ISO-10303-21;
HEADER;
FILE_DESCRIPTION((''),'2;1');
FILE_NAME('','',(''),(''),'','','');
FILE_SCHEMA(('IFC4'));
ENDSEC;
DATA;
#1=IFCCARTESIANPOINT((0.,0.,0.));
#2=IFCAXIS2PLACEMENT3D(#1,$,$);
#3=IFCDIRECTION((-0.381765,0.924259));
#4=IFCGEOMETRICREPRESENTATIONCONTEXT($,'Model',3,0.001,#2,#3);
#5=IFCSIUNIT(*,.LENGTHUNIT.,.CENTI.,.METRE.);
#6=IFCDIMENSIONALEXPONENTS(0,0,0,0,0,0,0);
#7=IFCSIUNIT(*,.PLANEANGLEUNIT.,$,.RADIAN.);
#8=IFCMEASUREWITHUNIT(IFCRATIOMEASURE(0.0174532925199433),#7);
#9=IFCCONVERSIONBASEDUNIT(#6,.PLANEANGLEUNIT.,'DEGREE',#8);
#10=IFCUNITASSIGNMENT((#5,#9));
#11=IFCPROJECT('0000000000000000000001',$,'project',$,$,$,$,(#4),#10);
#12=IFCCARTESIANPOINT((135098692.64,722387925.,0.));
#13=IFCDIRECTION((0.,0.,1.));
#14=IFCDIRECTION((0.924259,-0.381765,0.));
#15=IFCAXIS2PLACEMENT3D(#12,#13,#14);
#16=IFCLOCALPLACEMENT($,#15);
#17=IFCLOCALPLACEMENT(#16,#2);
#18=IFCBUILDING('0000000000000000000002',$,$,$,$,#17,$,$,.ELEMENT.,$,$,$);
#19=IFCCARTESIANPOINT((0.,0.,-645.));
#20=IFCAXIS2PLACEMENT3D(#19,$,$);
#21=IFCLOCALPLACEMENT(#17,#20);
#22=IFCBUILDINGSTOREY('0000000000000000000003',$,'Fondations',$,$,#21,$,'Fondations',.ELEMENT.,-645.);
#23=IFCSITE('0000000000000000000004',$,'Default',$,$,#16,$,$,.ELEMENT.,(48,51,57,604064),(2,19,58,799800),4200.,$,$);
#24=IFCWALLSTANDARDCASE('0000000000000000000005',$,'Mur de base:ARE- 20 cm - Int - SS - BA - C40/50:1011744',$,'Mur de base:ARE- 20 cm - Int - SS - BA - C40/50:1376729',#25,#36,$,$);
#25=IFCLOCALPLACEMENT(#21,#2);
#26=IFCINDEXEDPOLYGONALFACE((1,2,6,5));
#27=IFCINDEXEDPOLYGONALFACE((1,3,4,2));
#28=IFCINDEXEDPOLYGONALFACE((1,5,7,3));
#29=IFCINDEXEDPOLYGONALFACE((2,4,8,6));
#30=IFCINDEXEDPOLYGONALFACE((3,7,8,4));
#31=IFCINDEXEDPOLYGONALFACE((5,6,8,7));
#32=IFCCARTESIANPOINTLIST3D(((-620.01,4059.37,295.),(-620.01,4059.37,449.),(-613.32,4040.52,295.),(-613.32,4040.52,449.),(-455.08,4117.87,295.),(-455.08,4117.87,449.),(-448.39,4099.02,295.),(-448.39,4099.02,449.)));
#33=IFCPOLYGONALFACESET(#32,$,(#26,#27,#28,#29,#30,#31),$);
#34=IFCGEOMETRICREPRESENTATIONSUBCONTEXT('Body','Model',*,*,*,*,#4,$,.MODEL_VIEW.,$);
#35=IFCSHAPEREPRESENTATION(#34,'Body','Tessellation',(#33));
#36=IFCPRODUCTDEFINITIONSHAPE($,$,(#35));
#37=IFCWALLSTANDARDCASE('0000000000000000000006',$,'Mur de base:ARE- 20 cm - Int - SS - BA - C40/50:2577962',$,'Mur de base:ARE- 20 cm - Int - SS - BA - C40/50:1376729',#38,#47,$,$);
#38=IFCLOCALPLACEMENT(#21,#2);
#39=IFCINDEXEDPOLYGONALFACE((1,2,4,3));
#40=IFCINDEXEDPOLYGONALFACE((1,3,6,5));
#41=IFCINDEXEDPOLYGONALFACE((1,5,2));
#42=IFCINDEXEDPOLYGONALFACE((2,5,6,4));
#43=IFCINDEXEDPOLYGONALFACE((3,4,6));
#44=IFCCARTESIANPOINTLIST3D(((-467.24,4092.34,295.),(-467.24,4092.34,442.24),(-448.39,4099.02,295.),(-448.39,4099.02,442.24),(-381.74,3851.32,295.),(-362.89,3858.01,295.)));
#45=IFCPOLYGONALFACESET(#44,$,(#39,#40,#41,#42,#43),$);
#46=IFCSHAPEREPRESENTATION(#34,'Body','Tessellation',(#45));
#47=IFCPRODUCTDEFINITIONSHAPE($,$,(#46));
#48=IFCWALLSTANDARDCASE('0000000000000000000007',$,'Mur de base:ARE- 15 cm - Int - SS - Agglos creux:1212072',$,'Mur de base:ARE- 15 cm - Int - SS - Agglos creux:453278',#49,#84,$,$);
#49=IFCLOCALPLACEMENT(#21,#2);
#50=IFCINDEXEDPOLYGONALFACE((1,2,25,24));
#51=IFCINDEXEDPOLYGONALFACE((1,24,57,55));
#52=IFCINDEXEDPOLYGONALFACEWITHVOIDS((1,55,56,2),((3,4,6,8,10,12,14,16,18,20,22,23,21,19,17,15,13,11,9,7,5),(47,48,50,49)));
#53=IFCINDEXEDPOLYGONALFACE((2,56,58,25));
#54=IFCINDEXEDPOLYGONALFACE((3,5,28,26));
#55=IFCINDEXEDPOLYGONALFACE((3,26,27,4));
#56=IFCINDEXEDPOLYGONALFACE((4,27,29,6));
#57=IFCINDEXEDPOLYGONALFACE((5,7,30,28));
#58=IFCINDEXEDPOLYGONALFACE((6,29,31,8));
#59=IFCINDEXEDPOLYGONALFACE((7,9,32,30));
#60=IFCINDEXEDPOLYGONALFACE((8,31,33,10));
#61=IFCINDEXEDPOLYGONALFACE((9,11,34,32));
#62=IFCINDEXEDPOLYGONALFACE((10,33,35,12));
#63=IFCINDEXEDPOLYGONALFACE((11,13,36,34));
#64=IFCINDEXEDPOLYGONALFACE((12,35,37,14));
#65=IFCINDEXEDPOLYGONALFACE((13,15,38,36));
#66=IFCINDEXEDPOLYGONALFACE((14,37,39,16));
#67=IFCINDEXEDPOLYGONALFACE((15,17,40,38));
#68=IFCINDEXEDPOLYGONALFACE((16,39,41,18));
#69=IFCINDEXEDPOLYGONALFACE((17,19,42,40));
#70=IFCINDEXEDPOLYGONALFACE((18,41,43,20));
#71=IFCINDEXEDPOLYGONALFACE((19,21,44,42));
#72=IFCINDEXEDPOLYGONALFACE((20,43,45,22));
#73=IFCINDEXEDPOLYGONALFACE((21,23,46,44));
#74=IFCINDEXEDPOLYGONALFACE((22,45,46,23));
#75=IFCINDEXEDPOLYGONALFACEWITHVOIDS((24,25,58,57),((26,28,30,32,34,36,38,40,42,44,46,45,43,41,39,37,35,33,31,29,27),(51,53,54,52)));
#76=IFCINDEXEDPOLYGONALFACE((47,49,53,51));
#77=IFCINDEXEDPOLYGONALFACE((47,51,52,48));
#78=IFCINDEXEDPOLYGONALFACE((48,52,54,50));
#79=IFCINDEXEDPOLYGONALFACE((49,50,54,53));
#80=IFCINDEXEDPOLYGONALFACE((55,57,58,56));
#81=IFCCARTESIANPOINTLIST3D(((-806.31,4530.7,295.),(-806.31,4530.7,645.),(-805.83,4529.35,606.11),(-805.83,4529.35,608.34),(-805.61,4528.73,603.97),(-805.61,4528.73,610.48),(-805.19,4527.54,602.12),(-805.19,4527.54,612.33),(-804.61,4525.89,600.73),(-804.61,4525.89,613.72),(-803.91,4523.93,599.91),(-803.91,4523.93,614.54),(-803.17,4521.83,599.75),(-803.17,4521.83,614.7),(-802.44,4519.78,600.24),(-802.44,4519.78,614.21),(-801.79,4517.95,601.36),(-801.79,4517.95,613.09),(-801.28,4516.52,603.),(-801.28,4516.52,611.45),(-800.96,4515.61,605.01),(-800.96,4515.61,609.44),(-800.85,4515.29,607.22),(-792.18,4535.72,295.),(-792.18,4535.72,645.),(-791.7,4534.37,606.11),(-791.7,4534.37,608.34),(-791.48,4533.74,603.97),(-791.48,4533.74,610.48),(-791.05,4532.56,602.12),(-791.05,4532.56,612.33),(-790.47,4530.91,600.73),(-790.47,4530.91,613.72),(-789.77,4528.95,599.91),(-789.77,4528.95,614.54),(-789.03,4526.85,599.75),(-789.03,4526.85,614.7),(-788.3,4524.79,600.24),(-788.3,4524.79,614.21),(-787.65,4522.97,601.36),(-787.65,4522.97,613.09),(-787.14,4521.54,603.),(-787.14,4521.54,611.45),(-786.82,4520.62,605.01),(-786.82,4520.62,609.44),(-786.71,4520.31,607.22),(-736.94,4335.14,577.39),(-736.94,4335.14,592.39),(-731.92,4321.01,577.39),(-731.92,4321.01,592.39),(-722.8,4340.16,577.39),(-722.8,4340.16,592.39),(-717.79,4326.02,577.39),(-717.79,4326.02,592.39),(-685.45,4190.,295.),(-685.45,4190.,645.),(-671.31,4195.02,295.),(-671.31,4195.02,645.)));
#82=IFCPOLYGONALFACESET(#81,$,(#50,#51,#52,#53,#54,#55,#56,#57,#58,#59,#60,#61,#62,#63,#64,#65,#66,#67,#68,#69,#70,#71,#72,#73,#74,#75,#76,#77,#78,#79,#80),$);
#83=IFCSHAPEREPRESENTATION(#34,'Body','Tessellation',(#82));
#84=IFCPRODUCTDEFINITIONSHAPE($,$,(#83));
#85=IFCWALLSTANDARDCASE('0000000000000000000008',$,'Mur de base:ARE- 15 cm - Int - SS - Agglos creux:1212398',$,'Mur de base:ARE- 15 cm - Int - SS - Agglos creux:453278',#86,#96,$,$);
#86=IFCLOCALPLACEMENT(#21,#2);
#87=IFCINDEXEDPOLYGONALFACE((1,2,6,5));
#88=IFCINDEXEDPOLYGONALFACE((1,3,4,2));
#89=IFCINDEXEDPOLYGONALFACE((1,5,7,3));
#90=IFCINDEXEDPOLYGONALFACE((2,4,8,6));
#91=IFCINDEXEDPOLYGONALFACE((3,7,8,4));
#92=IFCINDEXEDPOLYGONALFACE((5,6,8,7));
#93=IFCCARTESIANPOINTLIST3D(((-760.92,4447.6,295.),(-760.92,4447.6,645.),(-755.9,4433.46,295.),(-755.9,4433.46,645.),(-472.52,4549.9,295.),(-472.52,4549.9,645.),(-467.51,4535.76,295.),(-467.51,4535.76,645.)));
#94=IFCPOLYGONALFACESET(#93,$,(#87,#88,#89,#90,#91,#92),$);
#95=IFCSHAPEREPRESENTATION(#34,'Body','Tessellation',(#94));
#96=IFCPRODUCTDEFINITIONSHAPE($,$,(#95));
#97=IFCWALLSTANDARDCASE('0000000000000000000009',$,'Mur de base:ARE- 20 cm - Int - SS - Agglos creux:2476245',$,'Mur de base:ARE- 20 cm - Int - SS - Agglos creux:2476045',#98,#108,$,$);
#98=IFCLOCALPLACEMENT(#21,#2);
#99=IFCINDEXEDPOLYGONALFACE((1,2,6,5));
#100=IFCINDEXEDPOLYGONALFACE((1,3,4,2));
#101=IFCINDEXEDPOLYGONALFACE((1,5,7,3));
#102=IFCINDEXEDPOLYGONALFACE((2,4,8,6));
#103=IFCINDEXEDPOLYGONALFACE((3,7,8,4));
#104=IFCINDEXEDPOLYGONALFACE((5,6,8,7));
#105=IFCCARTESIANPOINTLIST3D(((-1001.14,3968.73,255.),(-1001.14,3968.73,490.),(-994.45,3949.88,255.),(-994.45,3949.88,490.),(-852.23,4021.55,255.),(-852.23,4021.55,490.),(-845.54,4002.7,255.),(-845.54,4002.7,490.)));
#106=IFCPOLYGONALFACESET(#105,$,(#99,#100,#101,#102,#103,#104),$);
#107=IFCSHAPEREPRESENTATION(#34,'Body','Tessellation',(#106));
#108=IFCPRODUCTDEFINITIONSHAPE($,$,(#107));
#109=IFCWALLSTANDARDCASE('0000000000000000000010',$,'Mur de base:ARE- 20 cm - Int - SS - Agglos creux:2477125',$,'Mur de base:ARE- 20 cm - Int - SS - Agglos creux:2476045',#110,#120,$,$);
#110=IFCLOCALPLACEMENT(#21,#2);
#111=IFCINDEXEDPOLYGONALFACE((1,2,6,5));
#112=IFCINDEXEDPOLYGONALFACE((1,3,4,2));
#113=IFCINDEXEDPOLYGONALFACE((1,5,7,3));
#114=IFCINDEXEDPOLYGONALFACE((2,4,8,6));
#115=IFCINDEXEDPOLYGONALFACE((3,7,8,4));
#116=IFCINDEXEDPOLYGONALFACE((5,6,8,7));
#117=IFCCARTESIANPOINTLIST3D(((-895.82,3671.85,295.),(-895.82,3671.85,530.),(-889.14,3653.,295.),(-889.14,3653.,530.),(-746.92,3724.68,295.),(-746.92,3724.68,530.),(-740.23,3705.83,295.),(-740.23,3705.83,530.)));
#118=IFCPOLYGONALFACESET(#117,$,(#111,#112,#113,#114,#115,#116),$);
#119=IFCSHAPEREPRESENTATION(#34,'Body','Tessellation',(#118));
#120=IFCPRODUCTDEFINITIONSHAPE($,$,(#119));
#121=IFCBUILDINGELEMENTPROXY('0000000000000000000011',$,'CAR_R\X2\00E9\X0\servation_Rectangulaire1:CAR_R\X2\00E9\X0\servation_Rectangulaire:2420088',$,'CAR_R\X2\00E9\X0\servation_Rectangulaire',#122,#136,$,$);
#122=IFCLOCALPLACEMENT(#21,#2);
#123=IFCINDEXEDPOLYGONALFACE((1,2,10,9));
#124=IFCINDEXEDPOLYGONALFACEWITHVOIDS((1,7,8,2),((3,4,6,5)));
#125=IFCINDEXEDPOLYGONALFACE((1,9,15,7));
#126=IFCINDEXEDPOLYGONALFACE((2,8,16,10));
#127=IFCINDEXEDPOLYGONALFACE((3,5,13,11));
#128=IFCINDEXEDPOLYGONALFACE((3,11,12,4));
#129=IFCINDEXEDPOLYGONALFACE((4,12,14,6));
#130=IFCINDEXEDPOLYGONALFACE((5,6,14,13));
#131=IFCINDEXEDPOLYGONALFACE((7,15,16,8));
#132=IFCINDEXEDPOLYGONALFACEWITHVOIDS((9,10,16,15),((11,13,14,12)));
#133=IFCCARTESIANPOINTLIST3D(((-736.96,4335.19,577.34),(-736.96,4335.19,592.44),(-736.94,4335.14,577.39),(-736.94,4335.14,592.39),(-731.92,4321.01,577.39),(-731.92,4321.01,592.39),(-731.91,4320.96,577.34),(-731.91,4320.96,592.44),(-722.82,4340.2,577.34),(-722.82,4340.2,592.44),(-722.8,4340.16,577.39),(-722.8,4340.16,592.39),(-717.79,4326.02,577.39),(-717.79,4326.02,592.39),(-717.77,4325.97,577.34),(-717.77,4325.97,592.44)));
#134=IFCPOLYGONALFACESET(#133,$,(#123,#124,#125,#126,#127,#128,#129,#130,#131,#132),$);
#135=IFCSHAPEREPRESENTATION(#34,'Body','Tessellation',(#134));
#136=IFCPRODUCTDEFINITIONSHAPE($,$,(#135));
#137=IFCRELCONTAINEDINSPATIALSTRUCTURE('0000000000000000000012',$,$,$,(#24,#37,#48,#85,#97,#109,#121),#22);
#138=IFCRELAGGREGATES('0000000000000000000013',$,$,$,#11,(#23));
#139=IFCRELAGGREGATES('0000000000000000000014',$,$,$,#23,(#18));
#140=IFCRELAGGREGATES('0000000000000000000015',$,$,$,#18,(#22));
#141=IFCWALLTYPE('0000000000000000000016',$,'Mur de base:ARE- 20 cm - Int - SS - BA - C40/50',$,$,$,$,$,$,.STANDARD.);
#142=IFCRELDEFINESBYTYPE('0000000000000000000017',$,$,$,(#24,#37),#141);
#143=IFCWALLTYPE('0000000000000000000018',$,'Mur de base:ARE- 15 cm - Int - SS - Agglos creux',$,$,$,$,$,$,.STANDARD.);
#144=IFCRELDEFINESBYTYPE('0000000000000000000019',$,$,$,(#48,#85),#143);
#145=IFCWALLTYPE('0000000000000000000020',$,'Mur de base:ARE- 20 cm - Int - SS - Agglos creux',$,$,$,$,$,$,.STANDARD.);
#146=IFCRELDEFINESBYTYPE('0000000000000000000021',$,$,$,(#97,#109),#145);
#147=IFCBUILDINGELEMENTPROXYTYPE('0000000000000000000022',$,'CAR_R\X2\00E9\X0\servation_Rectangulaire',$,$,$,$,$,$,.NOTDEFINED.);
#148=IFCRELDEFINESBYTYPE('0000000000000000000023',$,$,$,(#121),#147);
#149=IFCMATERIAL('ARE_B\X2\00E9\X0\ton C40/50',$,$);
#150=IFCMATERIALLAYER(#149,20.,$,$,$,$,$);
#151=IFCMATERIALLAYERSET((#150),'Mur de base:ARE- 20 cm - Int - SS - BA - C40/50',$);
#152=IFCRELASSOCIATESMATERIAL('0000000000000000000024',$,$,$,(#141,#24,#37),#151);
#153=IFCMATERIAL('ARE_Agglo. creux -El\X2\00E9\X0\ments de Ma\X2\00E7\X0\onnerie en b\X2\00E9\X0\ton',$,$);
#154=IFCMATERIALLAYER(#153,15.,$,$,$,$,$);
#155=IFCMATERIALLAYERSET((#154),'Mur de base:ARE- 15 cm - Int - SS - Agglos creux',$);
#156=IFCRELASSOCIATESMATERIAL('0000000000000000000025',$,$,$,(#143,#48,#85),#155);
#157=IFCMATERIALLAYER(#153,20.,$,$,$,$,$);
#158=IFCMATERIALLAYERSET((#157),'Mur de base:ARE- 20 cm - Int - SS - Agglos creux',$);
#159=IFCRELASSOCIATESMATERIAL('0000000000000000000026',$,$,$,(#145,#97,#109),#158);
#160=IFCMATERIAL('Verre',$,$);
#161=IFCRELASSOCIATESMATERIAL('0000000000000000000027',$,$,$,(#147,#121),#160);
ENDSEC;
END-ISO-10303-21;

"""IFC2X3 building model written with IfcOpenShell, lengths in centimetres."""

from ifc_helpers import new_model, entity, si_unit, converted_unit, direction, frame, frame_2d, origin, place, context, subcontext, project, spatial, polyline, rectangle, circle, outline, extrude, clip, halfspace, source, transform, mapped, material, layer, layer_set, layer_usage, type_object, type_shapes, element, save


model = new_model("IFC2X3")

# Units and contexts
model_context = context("Model", 3, precision=0.001, world=origin(), true_north=direction((-0.381765, 0.924259)))
body_context = subcontext(model_context, "Body", "Model", "MODEL_VIEW")
ifc_project = project(units=[si_unit("LENGTHUNIT", "METRE", prefix="CENTI"), converted_unit("PLANEANGLEUNIT", "DEGREE", entity("IfcRatioMeasure", 0.0174532925199433), si_unit("PLANEANGLEUNIT", "RADIAN"), dimensions=[0, 0, 0, 0, 0, 0, 0])], contexts=[model_context])

# Site, building, storey
site_placement = place(None, frame((135098692.64, 722387925.0, 0.0), z_axis=(0.0, 0.0, 1.0), x_axis=(0.924259, -0.381765, 0.0)))
site = spatial("IfcSite", under=ifc_project, at=site_placement, Name="Default", CompositionType="ELEMENT", RefLatitude=(48, 51, 57, 604064), RefLongitude=(2, 19, 58, 799800), RefElevation=4200.0)
building_placement = place(site_placement, origin())
building = spatial("IfcBuilding", under=site, at=building_placement, CompositionType="ELEMENT")
storey_placement = place(building_placement, frame((0.0, 0.0, -645.0)))
storey = spatial("IfcBuildingStorey", under=building, at=storey_placement, Name="Fondations", LongName="Fondations", CompositionType="ELEMENT", Elevation=-645.0)

# Shared definitions
ifc_material_1 = material(Name="ARE_Béton C40/50")

# Walls
ifc_layer_1 = layer(ifc_material_1, 20.0)
ifc_layer_set_1 = layer_set([ifc_layer_1], Name="Mur de base:ARE- 20 cm - Int - SS - BA - C40/50")
wall_type_1 = type_object("IfcWallType", Name="Mur de base:ARE- 20 cm - Int - SS - BA - C40/50", PredefinedType="STANDARD", material=ifc_layer_set_1)
ifc_layer_usage_1 = layer_usage(ifc_layer_set_1, "AXIS2", "NEGATIVE", 10.0)
wall_1_placement = place(storey_placement, frame((-616.67, 4049.94, 295.0), z_axis=(0.0, 0.0, 1.0), x_axis=(0.942456, 0.334331, 0.0)))
element("IfcWallStandardCase", 1, at=wall_1_placement, inside=storey, type_object=wall_type_1, material=ifc_layer_usage_1, Name="Mur de base:ARE- 20 cm - Int - SS - BA - C40/50:1011744", ObjectType="Mur de base:ARE- 20 cm - Int - SS - BA - C40/50:1376729", context=body_context, shape_type="SweptSolid", body=[
    extrude(rectangle(XDim=175.0, YDim=20.0, at=frame_2d((87.5, 0.0), x_axis=(-1.0, 0.0))), origin(), (0.0, 0.0, 1.0), 154.0),
])
ifc_layer_usage_2 = layer_usage(ifc_layer_set_1, "AXIS2", "POSITIVE", -10.0)
wall_2_placement = place(storey_placement, frame((-457.82, 4095.68, 295.0), z_axis=(0.0, 0.0, 1.0), x_axis=(0.334331, -0.942456, 0.0)))
element("IfcWallStandardCase", 2, at=wall_2_placement, inside=storey, type_object=wall_type_1, material=ifc_layer_usage_2, Name="Mur de base:ARE- 20 cm - Int - SS - BA - C40/50:2577962", ObjectType="Mur de base:ARE- 20 cm - Int - SS - BA - C40/50:1376729", context=body_context, shape_type="Clipping", body=[
    clip(extrude(rectangle(XDim=255.73, YDim=20.0, at=frame_2d((127.87, 0.0), x_axis=(-1.0, 0.0))), origin(), (0.0, 0.0, 1.0), 147.24), halfspace(frame((0.0, -10.0, 147.24), z_axis=(0.498977, 0.0, 0.866615), x_axis=(0.0, 1.0, 0.0)), False)),
])

# Wall, openings
ifc_material_2 = material(Name="ARE_Agglo. creux -Eléments de Maçonnerie en béton")
ifc_layer_2 = layer(ifc_material_2, 15.0)
ifc_layer_set_2 = layer_set([ifc_layer_2], Name="Mur de base:ARE- 15 cm - Int - SS - Agglos creux")
ifc_layer_usage_3 = layer_usage(ifc_layer_set_2, "AXIS2", "NEGATIVE", 7.5)
wall_type_2 = type_object("IfcWallType", Name="Mur de base:ARE- 15 cm - Int - SS - Agglos creux", PredefinedType="STANDARD", material=ifc_layer_set_2)
wall_3_placement = place(storey_placement, frame((-799.24, 4533.21, 295.0), z_axis=(0.0, 0.0, 1.0), x_axis=(0.334331, -0.942456, 0.0)))
wall_3 = element("IfcWallStandardCase", 3, at=wall_3_placement, inside=storey, type_object=wall_type_2, material=ifc_layer_usage_3, Name="Mur de base:ARE- 15 cm - Int - SS - Agglos creux:1212072", ObjectType="Mur de base:ARE- 15 cm - Int - SS - Agglos creux:453278", context=body_context, shape_type="SweptSolid", body=[
    extrude(rectangle(XDim=361.5, YDim=15.0, at=frame_2d((180.75, 0.0), x_axis=(-1.0, 0.0))), origin(), (0.0, 0.0, 1.0), 350.0),
])
opening_1_placement = place(wall_3_placement, origin())
element("IfcOpeningElement", 4, at=opening_1_placement, cuts=wall_3, ObjectType="Opening", context=body_context, shape_type="SweptSolid", body=[
    extrude(rectangle(XDim=15.0, YDim=15.0, at=frame_2d((0.0, 0.0), x_axis=(0.0, 1.0))), frame((215.0, -7.5, 289.89), z_axis=(0.0, 1.0, 0.0), x_axis=(1.0, 0.0, 0.0)), (0.0, 0.0, 1.0), 15.0),
])
opening_2_placement = place(wall_3_placement, origin())
element("IfcOpeningElement", 5, at=opening_2_placement, cuts=wall_3, ObjectType="Opening", context=body_context, shape_type="SweptSolid", body=[
    extrude(circle(Radius=7.5, at=frame_2d((0.0, 0.0), x_axis=(1.0, 0.0))), frame((8.85, -7.5, 312.22), z_axis=(0.0, 1.0, 0.0), x_axis=(1.0, 0.0, 0.0)), (0.0, 0.0, 1.0), 15.0),
])

# Walls
ifc_layer_usage_4 = layer_usage(ifc_layer_set_2, "AXIS2", "NEGATIVE", 7.5)
wall_4_placement = place(storey_placement, frame((-758.41, 4440.53, 295.0), z_axis=(0.0, 0.0, 1.0), x_axis=(0.942456, 0.334331, 0.0)))
element("IfcWallStandardCase", 6, at=wall_4_placement, inside=storey, type_object=wall_type_2, material=ifc_layer_usage_4, Name="Mur de base:ARE- 15 cm - Int - SS - Agglos creux:1212398", ObjectType="Mur de base:ARE- 15 cm - Int - SS - Agglos creux:453278", context=body_context, shape_type="SweptSolid", body=[
    extrude(rectangle(XDim=306.0, YDim=15.0, at=frame_2d((153.0, 0.0), x_axis=(-1.0, 0.0))), origin(), (0.0, 0.0, 1.0), 350.0),
])
ifc_layer_3 = layer(ifc_material_2, 20.0)
ifc_layer_set_3 = layer_set([ifc_layer_3], Name="Mur de base:ARE- 20 cm - Int - SS - Agglos creux")
ifc_layer_usage_5 = layer_usage(ifc_layer_set_3, "AXIS2", "NEGATIVE", 10.0)
wall_type_3 = type_object("IfcWallType", Name="Mur de base:ARE- 20 cm - Int - SS - Agglos creux", PredefinedType="STANDARD", material=ifc_layer_set_3)
wall_5_placement = place(storey_placement, frame((-848.89, 4012.13, 255.0), z_axis=(0.0, 0.0, 1.0), x_axis=(-0.942456, -0.334331, 0.0)))
element("IfcWallStandardCase", 7, at=wall_5_placement, inside=storey, type_object=wall_type_3, material=ifc_layer_usage_5, Name="Mur de base:ARE- 20 cm - Int - SS - Agglos creux:2476245", ObjectType="Mur de base:ARE- 20 cm - Int - SS - Agglos creux:2476045", context=body_context, shape_type="SweptSolid", body=[
    extrude(rectangle(XDim=158.0, YDim=20.0, at=frame_2d((79.0, 0.0), x_axis=(-1.0, 0.0))), origin(), (0.0, 0.0, 1.0), 235.0),
])
ifc_layer_usage_6 = layer_usage(ifc_layer_set_3, "AXIS2", "NEGATIVE", 10.0)
wall_6_placement = place(storey_placement, frame((-743.57, 3715.25, 295.0), z_axis=(0.0, 0.0, 1.0), x_axis=(-0.942456, -0.334331, 0.0)))
element("IfcWallStandardCase", 8, at=wall_6_placement, inside=storey, type_object=wall_type_3, material=ifc_layer_usage_6, Name="Mur de base:ARE- 20 cm - Int - SS - Agglos creux:2477125", ObjectType="Mur de base:ARE- 20 cm - Int - SS - Agglos creux:2476045", context=body_context, shape_type="SweptSolid", body=[
    extrude(rectangle(XDim=158.0, YDim=20.0, at=frame_2d((79.0, 0.0), x_axis=(-1.0, 0.0))), origin(), (0.0, 0.0, 1.0), 235.0),
])

# Building element proxy
ifc_material_3 = material(Name="Verre")
building_element_proxy_type_1 = type_object("IfcBuildingElementProxyType", Name="CAR_Réservation_Rectangulaire", PredefinedType="NOTDEFINED", material=ifc_material_3)
shared_shape_1 = source(origin(), body_context, "Body", "SweptSolid", [
    extrude(outline(polyline([(-7.55, -7.55), (7.55, -7.55), (7.55, 7.55), (-7.55, 7.55), (-7.55, -7.55)]), holes=[polyline([(7.5, -7.5), (-7.5, -7.5), (-7.5, 7.5), (7.5, 7.5), (7.5, -7.5)])]), frame((0.0, 0.0, -15.0), z_axis=(0.0, 0.0, 1.0), x_axis=(-1.0, 0.0, 0.0)), (0.0, 0.0, 1.0), 15.0),
])
type_shapes(building_element_proxy_type_1, [shared_shape_1])
proxy_1_placement = place(storey_placement, frame((-720.29, 4333.09, 584.89), z_axis=(0.942456, 0.334331, 0.0), x_axis=(-0.334331, 0.942456, 0.0)))
element("IfcBuildingElementProxy", 9, at=proxy_1_placement, inside=storey, type_object=building_element_proxy_type_1, material=ifc_material_3, Name="CAR_Réservation_Rectangulaire1:CAR_Réservation_Rectangulaire:2420088", ObjectType="CAR_Réservation_Rectangulaire", context=body_context, shape_type="MappedRepresentation", body=[
    mapped(shared_shape_1, transform((0.0, 0.0, 0.0), scale=1.0)),
])

save(model, "model.ifc")
